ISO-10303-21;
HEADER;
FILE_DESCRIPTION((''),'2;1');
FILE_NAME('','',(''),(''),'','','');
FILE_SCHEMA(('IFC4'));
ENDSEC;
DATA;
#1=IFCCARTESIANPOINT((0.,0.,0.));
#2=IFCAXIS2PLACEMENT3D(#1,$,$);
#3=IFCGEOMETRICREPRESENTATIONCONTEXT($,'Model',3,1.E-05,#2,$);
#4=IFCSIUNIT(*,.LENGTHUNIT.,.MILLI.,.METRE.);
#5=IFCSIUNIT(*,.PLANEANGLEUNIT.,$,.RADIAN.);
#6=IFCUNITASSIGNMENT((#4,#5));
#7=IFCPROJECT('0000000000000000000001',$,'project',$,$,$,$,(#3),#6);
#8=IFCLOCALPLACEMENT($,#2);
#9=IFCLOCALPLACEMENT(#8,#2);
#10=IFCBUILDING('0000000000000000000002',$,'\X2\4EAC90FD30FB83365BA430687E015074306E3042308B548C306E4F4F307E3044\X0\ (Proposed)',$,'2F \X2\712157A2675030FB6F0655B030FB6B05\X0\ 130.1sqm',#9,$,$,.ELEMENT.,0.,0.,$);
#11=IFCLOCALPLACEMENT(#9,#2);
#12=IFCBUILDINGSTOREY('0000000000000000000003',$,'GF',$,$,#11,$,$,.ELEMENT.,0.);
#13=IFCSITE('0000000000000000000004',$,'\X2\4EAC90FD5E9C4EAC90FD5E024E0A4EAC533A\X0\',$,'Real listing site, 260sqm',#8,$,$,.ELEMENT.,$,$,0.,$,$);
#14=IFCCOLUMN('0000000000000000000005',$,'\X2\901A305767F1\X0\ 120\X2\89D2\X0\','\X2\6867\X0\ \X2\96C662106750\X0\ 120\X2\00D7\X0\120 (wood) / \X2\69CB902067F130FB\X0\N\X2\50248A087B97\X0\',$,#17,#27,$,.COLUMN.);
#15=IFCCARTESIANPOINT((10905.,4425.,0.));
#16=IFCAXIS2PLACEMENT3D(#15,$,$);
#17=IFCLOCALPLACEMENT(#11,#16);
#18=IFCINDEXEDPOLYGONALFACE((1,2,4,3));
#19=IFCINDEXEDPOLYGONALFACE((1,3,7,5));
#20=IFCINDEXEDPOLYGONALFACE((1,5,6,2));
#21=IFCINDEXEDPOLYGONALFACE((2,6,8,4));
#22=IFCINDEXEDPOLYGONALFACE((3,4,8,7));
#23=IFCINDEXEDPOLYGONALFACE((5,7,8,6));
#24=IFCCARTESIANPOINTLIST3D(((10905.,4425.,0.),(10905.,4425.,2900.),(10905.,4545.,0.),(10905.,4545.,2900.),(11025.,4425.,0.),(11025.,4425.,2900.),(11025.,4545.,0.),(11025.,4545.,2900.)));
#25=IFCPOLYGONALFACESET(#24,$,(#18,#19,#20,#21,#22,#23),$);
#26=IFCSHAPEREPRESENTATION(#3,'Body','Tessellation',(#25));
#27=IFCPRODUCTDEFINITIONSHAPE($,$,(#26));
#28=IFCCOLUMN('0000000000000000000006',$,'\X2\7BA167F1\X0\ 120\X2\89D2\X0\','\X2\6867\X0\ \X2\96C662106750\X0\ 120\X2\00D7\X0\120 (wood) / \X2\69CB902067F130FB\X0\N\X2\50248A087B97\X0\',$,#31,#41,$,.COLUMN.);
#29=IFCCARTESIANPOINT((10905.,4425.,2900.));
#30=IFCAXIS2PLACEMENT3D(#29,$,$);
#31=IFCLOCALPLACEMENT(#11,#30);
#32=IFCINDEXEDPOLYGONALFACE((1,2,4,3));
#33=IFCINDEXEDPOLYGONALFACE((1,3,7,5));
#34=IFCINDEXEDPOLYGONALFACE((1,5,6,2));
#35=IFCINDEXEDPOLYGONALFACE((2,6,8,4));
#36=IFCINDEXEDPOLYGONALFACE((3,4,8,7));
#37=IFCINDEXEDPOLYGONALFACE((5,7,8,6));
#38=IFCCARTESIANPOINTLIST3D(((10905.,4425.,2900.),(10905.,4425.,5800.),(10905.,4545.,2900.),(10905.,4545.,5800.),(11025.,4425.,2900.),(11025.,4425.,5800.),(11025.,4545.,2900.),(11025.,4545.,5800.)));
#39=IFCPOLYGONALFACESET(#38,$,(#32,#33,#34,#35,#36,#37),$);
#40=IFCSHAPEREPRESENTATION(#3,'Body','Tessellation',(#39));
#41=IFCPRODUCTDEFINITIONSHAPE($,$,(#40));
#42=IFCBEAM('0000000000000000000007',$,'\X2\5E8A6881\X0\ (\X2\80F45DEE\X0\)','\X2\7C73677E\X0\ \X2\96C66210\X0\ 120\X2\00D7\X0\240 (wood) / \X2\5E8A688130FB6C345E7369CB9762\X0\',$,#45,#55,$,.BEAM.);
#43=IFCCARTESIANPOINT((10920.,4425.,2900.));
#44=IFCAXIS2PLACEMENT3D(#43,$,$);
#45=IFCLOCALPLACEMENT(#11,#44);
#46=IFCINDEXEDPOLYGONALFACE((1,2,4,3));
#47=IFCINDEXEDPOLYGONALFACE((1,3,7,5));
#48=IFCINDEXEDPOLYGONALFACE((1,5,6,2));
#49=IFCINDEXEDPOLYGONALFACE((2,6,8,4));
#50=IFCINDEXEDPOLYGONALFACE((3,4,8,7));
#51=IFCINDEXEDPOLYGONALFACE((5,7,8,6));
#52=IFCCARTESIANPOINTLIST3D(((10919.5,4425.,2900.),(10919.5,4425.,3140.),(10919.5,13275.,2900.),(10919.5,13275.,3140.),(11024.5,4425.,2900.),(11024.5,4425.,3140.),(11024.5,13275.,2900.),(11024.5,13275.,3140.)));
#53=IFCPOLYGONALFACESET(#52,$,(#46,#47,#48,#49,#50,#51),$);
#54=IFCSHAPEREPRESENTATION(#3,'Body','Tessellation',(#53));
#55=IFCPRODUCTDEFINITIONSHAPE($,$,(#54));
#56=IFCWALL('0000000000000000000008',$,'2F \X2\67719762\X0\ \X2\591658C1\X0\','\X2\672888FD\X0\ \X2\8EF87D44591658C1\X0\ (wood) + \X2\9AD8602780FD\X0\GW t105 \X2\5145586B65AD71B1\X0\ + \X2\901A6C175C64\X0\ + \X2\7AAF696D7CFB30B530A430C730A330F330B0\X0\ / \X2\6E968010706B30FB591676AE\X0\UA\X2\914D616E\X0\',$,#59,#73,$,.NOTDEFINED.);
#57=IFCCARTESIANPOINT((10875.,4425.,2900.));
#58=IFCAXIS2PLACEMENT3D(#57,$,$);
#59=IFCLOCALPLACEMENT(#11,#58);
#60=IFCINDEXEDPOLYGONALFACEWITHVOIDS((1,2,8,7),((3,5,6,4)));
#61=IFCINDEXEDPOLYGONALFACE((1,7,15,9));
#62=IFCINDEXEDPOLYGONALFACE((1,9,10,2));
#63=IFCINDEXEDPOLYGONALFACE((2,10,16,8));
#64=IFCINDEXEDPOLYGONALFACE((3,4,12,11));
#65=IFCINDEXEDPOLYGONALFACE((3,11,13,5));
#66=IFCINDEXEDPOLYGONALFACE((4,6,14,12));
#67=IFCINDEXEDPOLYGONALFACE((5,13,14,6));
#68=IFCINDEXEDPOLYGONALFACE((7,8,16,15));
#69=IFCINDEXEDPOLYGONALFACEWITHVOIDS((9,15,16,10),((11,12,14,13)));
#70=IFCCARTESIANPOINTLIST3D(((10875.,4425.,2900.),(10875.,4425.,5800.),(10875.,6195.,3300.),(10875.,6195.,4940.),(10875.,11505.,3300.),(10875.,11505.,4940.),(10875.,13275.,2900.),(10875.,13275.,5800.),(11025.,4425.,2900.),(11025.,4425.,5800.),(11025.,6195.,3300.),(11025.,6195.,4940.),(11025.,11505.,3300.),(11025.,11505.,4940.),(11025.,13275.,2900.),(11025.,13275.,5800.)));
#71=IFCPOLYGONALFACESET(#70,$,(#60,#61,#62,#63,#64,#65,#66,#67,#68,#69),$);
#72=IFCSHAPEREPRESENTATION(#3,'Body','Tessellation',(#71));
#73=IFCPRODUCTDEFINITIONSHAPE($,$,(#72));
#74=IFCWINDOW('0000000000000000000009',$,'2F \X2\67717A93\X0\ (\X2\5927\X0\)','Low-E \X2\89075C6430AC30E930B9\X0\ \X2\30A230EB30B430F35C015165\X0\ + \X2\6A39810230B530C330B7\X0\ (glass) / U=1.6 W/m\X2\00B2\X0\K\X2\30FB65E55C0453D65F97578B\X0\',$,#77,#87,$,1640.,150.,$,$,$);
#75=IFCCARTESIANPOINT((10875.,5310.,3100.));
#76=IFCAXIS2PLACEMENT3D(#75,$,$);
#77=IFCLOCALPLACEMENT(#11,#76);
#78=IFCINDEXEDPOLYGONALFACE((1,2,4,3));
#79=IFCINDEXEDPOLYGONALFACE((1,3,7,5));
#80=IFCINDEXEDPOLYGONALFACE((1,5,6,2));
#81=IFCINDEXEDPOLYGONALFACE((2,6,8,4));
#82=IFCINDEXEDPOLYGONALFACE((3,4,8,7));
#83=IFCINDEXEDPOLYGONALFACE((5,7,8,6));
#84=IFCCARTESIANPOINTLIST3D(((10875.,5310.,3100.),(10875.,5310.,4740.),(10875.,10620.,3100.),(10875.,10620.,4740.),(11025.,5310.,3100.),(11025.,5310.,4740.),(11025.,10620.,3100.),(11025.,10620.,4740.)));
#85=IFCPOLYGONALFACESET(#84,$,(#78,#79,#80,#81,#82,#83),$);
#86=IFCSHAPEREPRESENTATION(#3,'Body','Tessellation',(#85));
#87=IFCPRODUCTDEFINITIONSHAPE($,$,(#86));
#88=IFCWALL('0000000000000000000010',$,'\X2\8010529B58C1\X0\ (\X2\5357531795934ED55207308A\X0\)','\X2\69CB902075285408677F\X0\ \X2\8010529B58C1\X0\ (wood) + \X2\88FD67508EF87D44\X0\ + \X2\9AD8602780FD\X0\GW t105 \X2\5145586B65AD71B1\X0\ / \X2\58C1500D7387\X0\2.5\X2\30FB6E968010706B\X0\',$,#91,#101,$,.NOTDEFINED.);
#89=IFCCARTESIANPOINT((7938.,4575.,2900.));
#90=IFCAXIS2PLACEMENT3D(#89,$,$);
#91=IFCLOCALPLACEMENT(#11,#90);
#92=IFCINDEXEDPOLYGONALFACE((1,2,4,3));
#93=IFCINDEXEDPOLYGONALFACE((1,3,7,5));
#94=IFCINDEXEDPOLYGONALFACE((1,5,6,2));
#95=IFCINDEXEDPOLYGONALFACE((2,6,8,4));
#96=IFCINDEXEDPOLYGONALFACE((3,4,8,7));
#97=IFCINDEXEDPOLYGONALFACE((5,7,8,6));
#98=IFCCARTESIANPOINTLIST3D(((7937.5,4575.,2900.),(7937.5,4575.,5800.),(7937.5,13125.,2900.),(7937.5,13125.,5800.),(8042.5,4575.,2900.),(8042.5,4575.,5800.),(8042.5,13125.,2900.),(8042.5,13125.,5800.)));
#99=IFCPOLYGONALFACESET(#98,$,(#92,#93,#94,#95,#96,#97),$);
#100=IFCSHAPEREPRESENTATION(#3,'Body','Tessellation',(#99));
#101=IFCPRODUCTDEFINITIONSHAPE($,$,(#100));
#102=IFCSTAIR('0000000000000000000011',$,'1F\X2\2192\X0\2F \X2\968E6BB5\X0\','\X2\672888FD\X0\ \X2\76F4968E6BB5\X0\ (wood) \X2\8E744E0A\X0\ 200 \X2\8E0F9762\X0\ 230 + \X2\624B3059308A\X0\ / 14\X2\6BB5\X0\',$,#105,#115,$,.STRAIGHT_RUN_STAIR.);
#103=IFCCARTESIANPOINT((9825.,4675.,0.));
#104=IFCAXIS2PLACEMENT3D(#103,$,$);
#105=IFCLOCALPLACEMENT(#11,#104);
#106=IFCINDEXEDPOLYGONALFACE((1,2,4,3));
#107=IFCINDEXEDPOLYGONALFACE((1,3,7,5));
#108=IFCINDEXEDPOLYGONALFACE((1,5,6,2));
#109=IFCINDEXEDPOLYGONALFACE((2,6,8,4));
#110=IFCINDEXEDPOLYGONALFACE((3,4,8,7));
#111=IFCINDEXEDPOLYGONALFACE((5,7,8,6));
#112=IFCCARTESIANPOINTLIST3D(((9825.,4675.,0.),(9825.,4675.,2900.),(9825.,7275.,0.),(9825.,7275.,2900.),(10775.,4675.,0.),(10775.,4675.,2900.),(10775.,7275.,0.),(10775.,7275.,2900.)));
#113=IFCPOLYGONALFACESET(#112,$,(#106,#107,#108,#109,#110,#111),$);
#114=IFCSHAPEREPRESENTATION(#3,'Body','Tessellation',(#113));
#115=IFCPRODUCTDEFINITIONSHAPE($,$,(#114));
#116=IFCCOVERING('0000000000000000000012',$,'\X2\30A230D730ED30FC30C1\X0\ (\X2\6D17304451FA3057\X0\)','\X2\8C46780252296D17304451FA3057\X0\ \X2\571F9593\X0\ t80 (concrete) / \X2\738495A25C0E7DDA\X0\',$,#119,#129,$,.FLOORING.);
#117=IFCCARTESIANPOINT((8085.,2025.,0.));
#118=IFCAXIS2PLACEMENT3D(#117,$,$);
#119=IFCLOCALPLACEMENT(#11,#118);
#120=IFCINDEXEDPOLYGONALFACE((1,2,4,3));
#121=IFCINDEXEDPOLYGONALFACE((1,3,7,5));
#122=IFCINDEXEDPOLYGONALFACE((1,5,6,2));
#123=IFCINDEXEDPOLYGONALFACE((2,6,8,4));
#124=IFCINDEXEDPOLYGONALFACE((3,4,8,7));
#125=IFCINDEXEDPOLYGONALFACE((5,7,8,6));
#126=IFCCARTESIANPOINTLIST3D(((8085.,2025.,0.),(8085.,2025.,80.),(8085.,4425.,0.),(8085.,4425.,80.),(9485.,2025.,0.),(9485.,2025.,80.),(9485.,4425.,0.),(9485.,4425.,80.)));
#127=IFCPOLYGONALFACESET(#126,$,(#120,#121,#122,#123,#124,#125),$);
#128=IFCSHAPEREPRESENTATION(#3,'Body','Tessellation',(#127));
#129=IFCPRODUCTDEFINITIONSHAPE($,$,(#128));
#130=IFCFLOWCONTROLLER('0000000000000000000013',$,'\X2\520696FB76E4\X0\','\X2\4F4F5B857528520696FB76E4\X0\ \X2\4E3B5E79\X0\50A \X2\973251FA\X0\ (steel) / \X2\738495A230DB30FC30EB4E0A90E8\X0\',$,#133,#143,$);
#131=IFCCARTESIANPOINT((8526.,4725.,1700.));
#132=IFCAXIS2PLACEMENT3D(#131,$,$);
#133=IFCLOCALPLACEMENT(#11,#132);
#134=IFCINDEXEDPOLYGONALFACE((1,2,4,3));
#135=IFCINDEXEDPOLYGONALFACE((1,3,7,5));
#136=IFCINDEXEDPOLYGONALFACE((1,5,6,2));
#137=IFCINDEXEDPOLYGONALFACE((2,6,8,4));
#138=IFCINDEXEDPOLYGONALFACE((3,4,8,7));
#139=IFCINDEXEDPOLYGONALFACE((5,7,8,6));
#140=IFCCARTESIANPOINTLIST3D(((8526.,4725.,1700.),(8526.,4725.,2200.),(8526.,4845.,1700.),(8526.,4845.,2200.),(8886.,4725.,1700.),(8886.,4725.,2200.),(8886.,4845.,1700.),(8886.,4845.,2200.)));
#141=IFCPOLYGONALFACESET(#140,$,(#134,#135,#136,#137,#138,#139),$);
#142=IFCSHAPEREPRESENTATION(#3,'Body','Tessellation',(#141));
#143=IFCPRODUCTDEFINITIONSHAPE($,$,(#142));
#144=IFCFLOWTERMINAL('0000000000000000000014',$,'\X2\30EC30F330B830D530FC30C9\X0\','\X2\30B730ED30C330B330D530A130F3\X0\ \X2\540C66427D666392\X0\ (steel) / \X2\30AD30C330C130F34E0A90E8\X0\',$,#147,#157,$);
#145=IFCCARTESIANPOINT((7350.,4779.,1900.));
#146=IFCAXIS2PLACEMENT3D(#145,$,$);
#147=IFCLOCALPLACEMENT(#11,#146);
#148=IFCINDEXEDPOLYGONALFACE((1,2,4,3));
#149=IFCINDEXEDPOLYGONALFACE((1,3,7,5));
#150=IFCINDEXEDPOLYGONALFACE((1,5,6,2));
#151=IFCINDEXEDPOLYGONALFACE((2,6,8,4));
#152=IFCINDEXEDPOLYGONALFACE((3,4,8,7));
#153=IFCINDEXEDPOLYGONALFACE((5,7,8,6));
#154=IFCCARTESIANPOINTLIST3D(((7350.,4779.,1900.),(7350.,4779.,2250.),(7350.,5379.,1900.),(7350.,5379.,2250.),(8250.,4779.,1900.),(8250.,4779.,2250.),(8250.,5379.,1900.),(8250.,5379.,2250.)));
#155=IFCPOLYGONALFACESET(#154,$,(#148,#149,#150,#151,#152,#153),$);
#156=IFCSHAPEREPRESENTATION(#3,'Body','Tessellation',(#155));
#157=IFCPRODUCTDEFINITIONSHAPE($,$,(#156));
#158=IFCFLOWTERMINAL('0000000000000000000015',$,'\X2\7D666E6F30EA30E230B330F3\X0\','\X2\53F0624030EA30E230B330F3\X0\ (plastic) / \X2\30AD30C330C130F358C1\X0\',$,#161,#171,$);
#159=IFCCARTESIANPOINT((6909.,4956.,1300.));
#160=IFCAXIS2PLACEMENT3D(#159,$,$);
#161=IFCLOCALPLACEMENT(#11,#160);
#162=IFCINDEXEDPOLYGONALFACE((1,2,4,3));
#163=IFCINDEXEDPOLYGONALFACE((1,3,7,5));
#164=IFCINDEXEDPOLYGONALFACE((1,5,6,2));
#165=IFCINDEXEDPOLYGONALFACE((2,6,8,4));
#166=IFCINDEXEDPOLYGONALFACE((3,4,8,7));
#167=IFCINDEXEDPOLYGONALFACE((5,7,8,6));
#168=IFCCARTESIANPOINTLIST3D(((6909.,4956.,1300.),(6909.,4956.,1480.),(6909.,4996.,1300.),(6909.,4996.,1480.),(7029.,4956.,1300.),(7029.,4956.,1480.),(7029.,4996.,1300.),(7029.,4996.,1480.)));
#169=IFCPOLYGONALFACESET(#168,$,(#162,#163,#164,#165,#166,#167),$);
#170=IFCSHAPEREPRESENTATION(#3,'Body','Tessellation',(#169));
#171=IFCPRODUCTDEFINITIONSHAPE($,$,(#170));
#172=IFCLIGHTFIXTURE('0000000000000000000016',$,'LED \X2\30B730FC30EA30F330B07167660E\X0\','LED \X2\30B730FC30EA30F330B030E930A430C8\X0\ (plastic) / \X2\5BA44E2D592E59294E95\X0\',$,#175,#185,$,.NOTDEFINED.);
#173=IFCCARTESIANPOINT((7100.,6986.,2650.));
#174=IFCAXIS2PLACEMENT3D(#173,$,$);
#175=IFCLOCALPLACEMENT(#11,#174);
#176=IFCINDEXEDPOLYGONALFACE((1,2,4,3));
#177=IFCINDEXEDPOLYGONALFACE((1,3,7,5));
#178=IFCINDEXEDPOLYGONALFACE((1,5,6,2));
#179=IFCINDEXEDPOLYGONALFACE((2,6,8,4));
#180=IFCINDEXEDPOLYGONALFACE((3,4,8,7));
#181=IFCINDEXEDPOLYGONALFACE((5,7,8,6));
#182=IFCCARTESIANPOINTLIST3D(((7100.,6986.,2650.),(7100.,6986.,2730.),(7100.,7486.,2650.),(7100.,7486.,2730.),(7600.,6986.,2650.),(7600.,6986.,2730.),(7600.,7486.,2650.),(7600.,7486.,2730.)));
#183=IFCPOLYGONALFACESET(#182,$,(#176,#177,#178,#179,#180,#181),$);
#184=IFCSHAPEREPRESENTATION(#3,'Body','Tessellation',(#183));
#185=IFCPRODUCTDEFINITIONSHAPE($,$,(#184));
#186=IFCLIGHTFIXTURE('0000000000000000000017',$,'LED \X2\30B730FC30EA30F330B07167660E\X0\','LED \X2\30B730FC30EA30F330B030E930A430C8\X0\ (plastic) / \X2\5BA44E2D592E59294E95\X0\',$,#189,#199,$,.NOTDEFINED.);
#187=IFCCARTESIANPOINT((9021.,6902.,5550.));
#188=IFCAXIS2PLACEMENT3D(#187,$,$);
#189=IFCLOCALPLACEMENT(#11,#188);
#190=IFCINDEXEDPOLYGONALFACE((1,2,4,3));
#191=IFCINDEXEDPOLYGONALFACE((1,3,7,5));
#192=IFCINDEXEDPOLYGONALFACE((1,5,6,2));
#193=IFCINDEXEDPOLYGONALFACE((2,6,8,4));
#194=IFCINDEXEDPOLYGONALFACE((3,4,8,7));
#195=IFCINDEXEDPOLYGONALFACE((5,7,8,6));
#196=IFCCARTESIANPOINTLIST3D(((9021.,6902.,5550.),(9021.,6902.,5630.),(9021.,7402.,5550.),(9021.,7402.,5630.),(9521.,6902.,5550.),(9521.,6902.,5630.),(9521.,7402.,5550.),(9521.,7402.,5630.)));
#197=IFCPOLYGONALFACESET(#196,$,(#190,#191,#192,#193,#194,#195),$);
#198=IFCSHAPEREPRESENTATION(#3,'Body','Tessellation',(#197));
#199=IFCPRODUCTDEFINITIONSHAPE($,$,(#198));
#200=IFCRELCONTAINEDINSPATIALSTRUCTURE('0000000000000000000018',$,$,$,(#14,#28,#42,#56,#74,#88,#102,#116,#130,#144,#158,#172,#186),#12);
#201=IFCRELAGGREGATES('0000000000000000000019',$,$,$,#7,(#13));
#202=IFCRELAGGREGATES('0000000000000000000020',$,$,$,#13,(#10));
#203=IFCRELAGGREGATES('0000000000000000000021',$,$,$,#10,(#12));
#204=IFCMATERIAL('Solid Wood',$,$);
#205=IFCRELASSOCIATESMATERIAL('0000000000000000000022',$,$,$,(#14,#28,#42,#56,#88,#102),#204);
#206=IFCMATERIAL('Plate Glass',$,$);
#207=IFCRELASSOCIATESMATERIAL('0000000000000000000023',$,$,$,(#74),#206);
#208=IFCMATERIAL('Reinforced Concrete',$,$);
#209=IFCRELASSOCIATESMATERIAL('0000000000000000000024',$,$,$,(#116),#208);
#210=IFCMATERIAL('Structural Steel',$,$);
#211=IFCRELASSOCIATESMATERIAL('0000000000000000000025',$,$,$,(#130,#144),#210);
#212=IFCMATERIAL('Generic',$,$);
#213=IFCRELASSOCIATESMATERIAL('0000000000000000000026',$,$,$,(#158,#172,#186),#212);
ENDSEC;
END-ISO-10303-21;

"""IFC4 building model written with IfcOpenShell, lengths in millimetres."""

from ifc_helpers import new_model, si_unit, frame, frame_2d, origin, place, context, project, spatial, rectangle, extrude, material, element, fill, save


model = new_model("IFC4")

# Units and contexts
model_context = context("Model", 3, precision=1e-05, world=origin())
ifc_project = project(units=[si_unit("LENGTHUNIT", "METRE", prefix="MILLI"), si_unit("PLANEANGLEUNIT", "RADIAN")], contexts=[model_context])

# Site, building, storey
site_placement = place(None, origin())
site = spatial("IfcSite", under=ifc_project, at=site_placement, Name="京都府京都市上京区", ObjectType="Real listing site, 260sqm", CompositionType="ELEMENT", RefElevation=0.0)
building_placement = place(site_placement, origin())
building = spatial("IfcBuilding", under=site, at=building_placement, Name="京都・茶室と縁側のある和の住まい (Proposed)", ObjectType="2F 無垢材・漆喰・欅 130.1sqm", CompositionType="ELEMENT", ElevationOfRefHeight=0.0, ElevationOfTerrain=0.0)
storey_placement = place(building_placement, origin())
storey = spatial("IfcBuildingStorey", under=building, at=storey_placement, Name="GF", CompositionType="ELEMENT", Elevation=0.0)

# Columns
ifc_material_1 = material(Name="Solid Wood")
column_1_placement = place(storey_placement, frame((10905.0, 4425.0, 0.0)))
element("IfcColumn", 1, at=column_1_placement, inside=storey, material=ifc_material_1, Name="通し柱 120角", Description="桧 集成材 120×120 (wood) / 構造柱・N値計算", PredefinedType="COLUMN", context=model_context, shape_type="SweptSolid", body=[
    extrude(rectangle(XDim=120.0, YDim=120.0, at=frame_2d((60.0, 60.0))), frame((10905.0, 4425.0, 0.0)), (0.0, 0.0, 1.0), 2900.0),
])
column_2_placement = place(storey_placement, frame((10905.0, 4425.0, 2900.0)))
element("IfcColumn", 2, at=column_2_placement, inside=storey, material=ifc_material_1, Name="管柱 120角", Description="桧 集成材 120×120 (wood) / 構造柱・N値計算", PredefinedType="COLUMN", context=model_context, shape_type="SweptSolid", body=[
    extrude(rectangle(XDim=120.0, YDim=120.0, at=frame_2d((60.0, 60.0))), frame((10905.0, 4425.0, 2900.0)), (0.0, 0.0, 1.0), 2900.0),
])

# Beam
beam_1_placement = place(storey_placement, frame((10920.0, 4425.0, 2900.0)))
element("IfcBeam", 3, at=beam_1_placement, inside=storey, material=ifc_material_1, Name="床梁 (胴差)", Description="米松 集成 120×240 (wood) / 床梁・水平構面", PredefinedType="BEAM", context=model_context, shape_type="SweptSolid", body=[
    extrude(rectangle(XDim=105.0, YDim=8850.0, at=frame_2d((52.0, 4425.0))), frame((10920.0, 4425.0, 2900.0)), (0.0, 0.0, 1.0), 240.0),
])

# Shared definitions
ifc_material_2 = material(Name="Plate Glass")

# Wall, opening, window
wall_1_placement = place(storey_placement, frame((10875.0, 4425.0, 2900.0)))
wall_1 = element("IfcWall", 4, at=wall_1_placement, inside=storey, material=ifc_material_1, Name="2F 東面 外壁", Description="木製 軸組外壁 (wood) + 高性能GW t105 充填断熱 + 通気層 + 窯業系サイディング / 準耐火・外皮UA配慮", PredefinedType="NOTDEFINED", context=model_context, shape_type="SweptSolid", body=[
    extrude(rectangle(XDim=150.0, YDim=8850.0, at=frame_2d((75.0, 4425.0))), frame((10875.0, 4425.0, 2900.0)), (0.0, 0.0, 1.0), 2900.0),
])
opening_1_placement = place(storey_placement, frame((10875.0, 5310.0, 3100.0)))
opening_1 = element("IfcOpeningElement", 5, at=opening_1_placement, cuts=wall_1, PredefinedType="NOTDEFINED", context=model_context, shape_type="SweptSolid", body=[
    extrude(rectangle(XDim=150.0, YDim=5310.0, at=frame_2d((75.0, 2655.0))), frame((10875.0, 5310.0, 3100.0)), (0.0, 0.0, 1.0), 1640.0),
])
window_1_placement = place(storey_placement, frame((10875.0, 5310.0, 3100.0)))
window_1 = element("IfcWindow", 6, at=window_1_placement, inside=storey, material=ifc_material_2, Name="2F 東窓 (大)", Description="Low-E 複層ガラス アルゴン封入 + 樹脂サッシ (glass) / U=1.6 W/m²K・日射取得型", OverallHeight=1640.0, OverallWidth=150.0, context=model_context, shape_type="SweptSolid", body=[
    extrude(rectangle(XDim=150.0, YDim=5310.0, at=frame_2d((75.0, 2655.0))), frame((10875.0, 5310.0, 3100.0)), (0.0, 0.0, 1.0), 1640.0),
])
fill(opening_1, window_1)

# Wall
wall_2_placement = place(storey_placement, frame((7938.0, 4575.0, 2900.0)))
element("IfcWall", 7, at=wall_2_placement, inside=storey, material=ifc_material_1, Name="耐力壁 (南北間仕切り)", Description="構造用合板 耐力壁 (wood) + 製材軸組 + 高性能GW t105 充填断熱 / 壁倍率2.5・準耐火", PredefinedType="NOTDEFINED", context=model_context, shape_type="SweptSolid", body=[
    extrude(rectangle(XDim=105.0, YDim=8550.0, at=frame_2d((52.0, 4275.0))), frame((7938.0, 4575.0, 2900.0)), (0.0, 0.0, 1.0), 2900.0),
])

# Stair
stair_placement = place(storey_placement, frame((9825.0, 4675.0, 0.0)))
element("IfcStair", 8, at=stair_placement, inside=storey, material=ifc_material_1, Name="1F→2F 階段", Description="木製 直階段 (wood) 蹴上 200 踏面 230 + 手すり / 14段", PredefinedType="STRAIGHT_RUN_STAIR", context=model_context, shape_type="SweptSolid", body=[
    extrude(rectangle(XDim=950.0, YDim=2600.0, at=frame_2d((475.0, 1300.0))), frame((9825.0, 4675.0, 0.0)), (0.0, 0.0, 1.0), 2900.0),
])

# Covering
ifc_material_3 = material(Name="Reinforced Concrete")
covering_placement = place(storey_placement, frame((8085.0, 2025.0, 0.0)))
element("IfcCovering", 9, at=covering_placement, inside=storey, material=ifc_material_3, Name="アプローチ (洗い出し)", Description="豆砂利洗い出し 土間 t80 (concrete) / 玄関導線", PredefinedType="FLOORING", context=model_context, shape_type="SweptSolid", body=[
    extrude(rectangle(XDim=1400.0, YDim=2400.0, at=frame_2d((700.0, 1200.0))), frame((8085.0, 2025.0, 0.0)), (0.0, 0.0, 1.0), 80.0),
])

# Flow controller
ifc_material_4 = material(Name="Structural Steel")
flow_controller_placement = place(storey_placement, frame((8526.0, 4725.0, 1700.0)))
element("IfcFlowController", 10, at=flow_controller_placement, inside=storey, material=ifc_material_4, Name="分電盤", Description="住宅用分電盤 主幹50A 露出 (steel) / 玄関ホール上部", context=model_context, shape_type="SweptSolid", body=[
    extrude(rectangle(XDim=360.0, YDim=120.0, at=frame_2d((180.0, 60.0))), frame((8526.0, 4725.0, 1700.0)), (0.0, 0.0, 1.0), 500.0),
])

# Flow terminals
flow_terminal_1_placement = place(storey_placement, frame((7350.0, 4779.0, 1900.0)))
element("IfcFlowTerminal", 11, at=flow_terminal_1_placement, inside=storey, material=ifc_material_4, Name="レンジフード", Description="シロッコファン 同時給排 (steel) / キッチン上部", context=model_context, shape_type="SweptSolid", body=[
    extrude(rectangle(XDim=900.0, YDim=600.0, at=frame_2d((450.0, 300.0))), frame((7350.0, 4779.0, 1900.0)), (0.0, 0.0, 1.0), 350.0),
])
ifc_material_5 = material(Name="Generic")
flow_terminal_2_placement = place(storey_placement, frame((6909.0, 4956.0, 1300.0)))
element("IfcFlowTerminal", 12, at=flow_terminal_2_placement, inside=storey, material=ifc_material_5, Name="給湯リモコン", Description="台所リモコン (plastic) / キッチン壁", context=model_context, shape_type="SweptSolid", body=[
    extrude(rectangle(XDim=120.0, YDim=40.0, at=frame_2d((60.0, 20.0))), frame((6909.0, 4956.0, 1300.0)), (0.0, 0.0, 1.0), 180.0),
])

# Light fixtures
light_fixture_1_placement = place(storey_placement, frame((7100.0, 6986.0, 2650.0)))
element("IfcLightFixture", 13, at=light_fixture_1_placement, inside=storey, material=ifc_material_5, Name="LED シーリング照明", Description="LED シーリングライト (plastic) / 室中央天井", PredefinedType="NOTDEFINED", context=model_context, shape_type="SweptSolid", body=[
    extrude(rectangle(XDim=500.0, YDim=500.0, at=frame_2d((250.0, 250.0))), frame((7100.0, 6986.0, 2650.0)), (0.0, 0.0, 1.0), 80.0),
])
light_fixture_2_placement = place(storey_placement, frame((9021.0, 6902.0, 5550.0)))
element("IfcLightFixture", 14, at=light_fixture_2_placement, inside=storey, material=ifc_material_5, Name="LED シーリング照明", Description="LED シーリングライト (plastic) / 室中央天井", PredefinedType="NOTDEFINED", context=model_context, shape_type="SweptSolid", body=[
    extrude(rectangle(XDim=500.0, YDim=500.0, at=frame_2d((250.0, 250.0))), frame((9021.0, 6902.0, 5550.0)), (0.0, 0.0, 1.0), 80.0),
])

save(model, "model.ifc")
